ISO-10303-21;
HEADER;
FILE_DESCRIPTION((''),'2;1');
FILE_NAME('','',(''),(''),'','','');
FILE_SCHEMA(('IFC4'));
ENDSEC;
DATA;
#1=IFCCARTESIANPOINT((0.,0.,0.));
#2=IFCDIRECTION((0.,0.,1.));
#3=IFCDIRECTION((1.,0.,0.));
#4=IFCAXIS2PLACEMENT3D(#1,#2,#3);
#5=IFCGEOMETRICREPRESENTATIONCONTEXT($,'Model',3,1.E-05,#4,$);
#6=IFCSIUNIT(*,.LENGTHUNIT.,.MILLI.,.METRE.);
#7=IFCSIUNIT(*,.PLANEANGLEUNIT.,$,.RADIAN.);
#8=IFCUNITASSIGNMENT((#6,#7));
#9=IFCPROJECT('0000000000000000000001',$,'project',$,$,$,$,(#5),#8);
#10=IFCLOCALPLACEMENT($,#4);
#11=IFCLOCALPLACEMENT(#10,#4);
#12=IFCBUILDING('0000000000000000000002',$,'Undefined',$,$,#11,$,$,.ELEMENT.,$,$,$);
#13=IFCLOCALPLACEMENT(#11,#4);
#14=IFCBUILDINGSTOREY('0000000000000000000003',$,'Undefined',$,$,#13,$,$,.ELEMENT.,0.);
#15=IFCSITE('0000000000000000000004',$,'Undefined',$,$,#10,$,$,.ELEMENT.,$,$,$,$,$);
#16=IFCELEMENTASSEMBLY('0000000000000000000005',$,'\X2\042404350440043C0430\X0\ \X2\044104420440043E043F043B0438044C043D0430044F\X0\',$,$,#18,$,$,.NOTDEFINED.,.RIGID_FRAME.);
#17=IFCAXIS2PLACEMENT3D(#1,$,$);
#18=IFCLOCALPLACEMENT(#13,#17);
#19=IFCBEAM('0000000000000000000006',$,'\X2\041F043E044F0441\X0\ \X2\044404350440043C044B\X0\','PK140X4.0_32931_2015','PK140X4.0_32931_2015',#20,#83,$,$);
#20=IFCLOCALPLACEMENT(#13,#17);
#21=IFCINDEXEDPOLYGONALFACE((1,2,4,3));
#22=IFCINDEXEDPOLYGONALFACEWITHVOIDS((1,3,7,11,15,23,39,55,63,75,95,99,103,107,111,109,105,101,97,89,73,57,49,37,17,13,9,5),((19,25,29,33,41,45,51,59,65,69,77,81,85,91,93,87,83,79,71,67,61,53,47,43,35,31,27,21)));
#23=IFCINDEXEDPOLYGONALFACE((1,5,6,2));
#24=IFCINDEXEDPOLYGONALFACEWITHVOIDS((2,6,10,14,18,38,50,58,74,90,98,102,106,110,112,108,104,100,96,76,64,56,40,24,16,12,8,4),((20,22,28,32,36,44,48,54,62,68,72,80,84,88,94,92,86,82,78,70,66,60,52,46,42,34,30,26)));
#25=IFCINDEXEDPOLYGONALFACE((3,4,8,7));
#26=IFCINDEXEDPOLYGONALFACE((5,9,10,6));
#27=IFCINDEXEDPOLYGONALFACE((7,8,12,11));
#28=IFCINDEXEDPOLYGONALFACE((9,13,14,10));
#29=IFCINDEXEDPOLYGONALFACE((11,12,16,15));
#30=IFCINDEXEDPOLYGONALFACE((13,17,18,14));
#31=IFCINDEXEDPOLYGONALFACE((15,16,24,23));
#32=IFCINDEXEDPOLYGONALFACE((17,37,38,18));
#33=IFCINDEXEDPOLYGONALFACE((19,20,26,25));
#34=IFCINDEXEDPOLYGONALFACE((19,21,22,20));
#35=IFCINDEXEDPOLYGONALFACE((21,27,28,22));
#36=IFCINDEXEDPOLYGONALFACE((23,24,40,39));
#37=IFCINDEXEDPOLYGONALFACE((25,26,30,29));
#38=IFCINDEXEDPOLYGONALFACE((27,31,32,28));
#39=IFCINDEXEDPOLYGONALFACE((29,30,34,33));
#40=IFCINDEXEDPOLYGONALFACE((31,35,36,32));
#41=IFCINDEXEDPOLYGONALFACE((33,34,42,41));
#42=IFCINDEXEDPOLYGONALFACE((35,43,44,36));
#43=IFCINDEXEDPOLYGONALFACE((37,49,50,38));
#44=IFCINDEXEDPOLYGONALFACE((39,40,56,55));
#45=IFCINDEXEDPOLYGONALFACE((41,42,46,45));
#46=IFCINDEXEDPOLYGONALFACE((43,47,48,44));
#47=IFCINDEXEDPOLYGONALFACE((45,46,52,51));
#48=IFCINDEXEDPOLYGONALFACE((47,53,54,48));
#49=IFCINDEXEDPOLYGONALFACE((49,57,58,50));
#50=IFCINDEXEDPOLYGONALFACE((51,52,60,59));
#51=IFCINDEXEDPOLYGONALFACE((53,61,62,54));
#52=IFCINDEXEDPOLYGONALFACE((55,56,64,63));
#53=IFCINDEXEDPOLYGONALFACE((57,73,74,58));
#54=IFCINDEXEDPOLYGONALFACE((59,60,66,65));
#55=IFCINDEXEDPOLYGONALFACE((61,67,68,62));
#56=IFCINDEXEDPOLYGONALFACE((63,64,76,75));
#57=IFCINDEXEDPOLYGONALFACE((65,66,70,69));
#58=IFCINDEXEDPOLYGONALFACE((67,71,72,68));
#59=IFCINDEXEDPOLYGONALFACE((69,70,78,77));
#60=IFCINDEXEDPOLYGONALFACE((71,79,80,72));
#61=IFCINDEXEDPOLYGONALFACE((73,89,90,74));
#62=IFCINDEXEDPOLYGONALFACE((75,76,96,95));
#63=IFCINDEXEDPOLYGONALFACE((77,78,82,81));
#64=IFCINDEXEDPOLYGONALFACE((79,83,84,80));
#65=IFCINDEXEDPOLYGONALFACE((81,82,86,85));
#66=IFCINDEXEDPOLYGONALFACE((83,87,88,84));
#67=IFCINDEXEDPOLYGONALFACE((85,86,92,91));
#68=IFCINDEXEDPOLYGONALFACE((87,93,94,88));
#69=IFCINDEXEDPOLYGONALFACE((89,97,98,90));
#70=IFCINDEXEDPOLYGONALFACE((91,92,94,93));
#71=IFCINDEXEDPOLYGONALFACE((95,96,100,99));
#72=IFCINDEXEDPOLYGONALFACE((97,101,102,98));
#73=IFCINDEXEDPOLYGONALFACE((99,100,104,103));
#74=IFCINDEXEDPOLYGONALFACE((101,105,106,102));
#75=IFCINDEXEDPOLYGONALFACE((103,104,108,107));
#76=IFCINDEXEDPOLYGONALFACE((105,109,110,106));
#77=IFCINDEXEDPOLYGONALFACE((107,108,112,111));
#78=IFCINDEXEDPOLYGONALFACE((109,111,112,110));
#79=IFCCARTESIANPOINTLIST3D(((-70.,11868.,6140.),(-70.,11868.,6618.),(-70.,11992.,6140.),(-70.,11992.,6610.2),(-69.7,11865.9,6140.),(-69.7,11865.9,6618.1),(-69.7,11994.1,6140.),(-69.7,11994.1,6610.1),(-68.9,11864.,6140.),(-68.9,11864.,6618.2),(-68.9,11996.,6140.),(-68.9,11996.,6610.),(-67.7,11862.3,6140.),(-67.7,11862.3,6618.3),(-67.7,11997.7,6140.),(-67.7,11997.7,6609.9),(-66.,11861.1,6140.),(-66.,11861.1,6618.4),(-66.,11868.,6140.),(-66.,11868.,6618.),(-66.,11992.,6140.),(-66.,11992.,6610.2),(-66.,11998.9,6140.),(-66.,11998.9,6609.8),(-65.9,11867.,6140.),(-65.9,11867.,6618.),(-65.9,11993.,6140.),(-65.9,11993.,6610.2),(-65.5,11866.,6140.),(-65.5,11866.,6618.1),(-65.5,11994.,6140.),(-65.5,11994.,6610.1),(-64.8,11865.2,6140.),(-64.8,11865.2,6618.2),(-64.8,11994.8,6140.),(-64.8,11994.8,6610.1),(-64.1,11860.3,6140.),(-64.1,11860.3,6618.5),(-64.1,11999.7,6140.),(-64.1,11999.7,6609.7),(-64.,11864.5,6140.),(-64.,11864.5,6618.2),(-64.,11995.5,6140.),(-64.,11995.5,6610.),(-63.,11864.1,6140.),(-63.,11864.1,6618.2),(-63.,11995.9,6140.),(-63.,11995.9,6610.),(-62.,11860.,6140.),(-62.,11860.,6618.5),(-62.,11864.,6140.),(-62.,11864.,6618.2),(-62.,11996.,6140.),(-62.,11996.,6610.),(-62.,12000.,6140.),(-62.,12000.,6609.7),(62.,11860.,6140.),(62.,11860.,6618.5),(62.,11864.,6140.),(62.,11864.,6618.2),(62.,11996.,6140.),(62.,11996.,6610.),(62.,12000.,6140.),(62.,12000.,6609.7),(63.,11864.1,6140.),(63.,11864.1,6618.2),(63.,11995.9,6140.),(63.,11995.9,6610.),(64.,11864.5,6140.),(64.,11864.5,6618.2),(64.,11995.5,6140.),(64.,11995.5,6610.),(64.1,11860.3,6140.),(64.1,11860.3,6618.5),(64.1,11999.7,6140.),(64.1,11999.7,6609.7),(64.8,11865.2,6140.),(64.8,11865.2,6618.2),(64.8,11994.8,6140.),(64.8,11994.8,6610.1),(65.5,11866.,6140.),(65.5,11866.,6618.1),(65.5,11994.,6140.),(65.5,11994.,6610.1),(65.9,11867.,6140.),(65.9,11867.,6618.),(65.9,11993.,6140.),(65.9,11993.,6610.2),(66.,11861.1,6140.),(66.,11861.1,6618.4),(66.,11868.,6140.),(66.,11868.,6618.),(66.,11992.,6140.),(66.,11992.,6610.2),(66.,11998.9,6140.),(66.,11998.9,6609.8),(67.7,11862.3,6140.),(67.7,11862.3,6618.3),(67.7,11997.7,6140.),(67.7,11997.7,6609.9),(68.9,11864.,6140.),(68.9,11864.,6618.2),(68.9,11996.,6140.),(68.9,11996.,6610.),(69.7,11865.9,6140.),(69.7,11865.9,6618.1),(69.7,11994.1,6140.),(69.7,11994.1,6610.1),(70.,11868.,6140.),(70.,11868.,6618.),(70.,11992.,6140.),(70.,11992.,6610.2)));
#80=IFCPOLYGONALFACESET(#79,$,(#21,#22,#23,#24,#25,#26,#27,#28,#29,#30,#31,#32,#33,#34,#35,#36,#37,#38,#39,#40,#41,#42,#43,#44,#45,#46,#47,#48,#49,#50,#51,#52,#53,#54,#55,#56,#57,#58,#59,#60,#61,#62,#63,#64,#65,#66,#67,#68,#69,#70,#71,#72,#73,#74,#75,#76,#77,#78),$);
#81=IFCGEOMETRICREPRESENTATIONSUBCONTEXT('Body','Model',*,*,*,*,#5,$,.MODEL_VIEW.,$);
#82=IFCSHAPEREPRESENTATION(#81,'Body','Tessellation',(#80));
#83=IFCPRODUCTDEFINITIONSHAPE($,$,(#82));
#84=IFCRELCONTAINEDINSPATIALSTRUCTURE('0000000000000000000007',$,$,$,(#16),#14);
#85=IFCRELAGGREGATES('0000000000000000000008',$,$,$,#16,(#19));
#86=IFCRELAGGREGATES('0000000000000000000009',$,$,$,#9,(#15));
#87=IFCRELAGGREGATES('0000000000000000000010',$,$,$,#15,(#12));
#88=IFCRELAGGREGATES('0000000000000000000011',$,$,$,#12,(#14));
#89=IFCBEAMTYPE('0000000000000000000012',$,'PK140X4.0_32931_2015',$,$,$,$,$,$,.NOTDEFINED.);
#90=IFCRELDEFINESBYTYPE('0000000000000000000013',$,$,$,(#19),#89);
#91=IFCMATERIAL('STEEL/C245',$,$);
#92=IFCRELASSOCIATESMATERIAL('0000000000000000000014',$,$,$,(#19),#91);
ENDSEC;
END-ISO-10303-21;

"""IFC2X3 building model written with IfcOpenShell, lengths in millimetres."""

from ifc_helpers import new_model, si_unit, frame, origin_with_axes, origin_2d_with_axis, place, context, subcontext, project, spatial, hollow_rectangle, extrude, clip, halfspace, material, type_object, element, aggregate, save


model = new_model("IFC2X3")

# Units and contexts
model_context = context("Model", 3, precision=1e-05, world=origin_with_axes())
body_context = subcontext(model_context, "Body", "Model", "MODEL_VIEW")
ifc_project = project(units=[si_unit("LENGTHUNIT", "METRE", prefix="MILLI"), si_unit("PLANEANGLEUNIT", "RADIAN")], contexts=[model_context])

# Site, building, storey
site_placement = place(None, origin_with_axes())
site = spatial("IfcSite", under=ifc_project, at=site_placement, Name="Undefined", CompositionType="ELEMENT")
building_placement = place(site_placement, origin_with_axes())
building = spatial("IfcBuilding", under=site, at=building_placement, Name="Undefined", CompositionType="ELEMENT")
storey_placement = place(building_placement, origin_with_axes())
storey = spatial("IfcBuildingStorey", under=building, at=storey_placement, Name="Undefined", CompositionType="ELEMENT", Elevation=0.0)

# Shared definitions
ifc_material = material(Name="STEEL/C245")

# Element assembly, beam
assembly_1_placement = place(storey_placement, origin_with_axes())
assembly_1 = element("IfcElementAssembly", 1, at=assembly_1_placement, inside=storey, Name="Ферма строплиьная", AssemblyPlace="NOTDEFINED", PredefinedType="RIGID_FRAME")
beam_type_1 = type_object("IfcBeamType", Name="PK140X4.0_32931_2015", PredefinedType="NOTDEFINED")
beam_1_placement = place(assembly_1_placement, frame((0.0, 11930.0, 6609.7), z_axis=(1.0, 0.0, 0.0), x_axis=(0.0, 0.0, -1.0)))
beam_1 = element("IfcBeam", 2, at=beam_1_placement, type_object=beam_type_1, material=ifc_material, Name="Пояс фермы", Description="PK140X4.0_32931_2015", ObjectType="PK140X4.0_32931_2015", context=body_context, shape_type="Clipping", body=[
    clip(extrude(hollow_rectangle(XDim=140.0, YDim=140.0, WallThickness=4.0, InnerFilletRadius=4.0, OuterFilletRadius=8.0, at=origin_2d_with_axis()), frame((469.7, 0.0, 0.0), z_axis=(-1.0, 0.0, 0.0), x_axis=(0.0, -1.0, 0.0)), (0.0, 0.0, 1.0), 478.5), halfspace(frame((-14.9, -167.6, 0.0), z_axis=(-0.998053, 0.062378, 0.0), x_axis=(0.0, 0.0, 1.0)), False)),
])
aggregate(assembly_1, [beam_1])

save(model, "model.ifc")
